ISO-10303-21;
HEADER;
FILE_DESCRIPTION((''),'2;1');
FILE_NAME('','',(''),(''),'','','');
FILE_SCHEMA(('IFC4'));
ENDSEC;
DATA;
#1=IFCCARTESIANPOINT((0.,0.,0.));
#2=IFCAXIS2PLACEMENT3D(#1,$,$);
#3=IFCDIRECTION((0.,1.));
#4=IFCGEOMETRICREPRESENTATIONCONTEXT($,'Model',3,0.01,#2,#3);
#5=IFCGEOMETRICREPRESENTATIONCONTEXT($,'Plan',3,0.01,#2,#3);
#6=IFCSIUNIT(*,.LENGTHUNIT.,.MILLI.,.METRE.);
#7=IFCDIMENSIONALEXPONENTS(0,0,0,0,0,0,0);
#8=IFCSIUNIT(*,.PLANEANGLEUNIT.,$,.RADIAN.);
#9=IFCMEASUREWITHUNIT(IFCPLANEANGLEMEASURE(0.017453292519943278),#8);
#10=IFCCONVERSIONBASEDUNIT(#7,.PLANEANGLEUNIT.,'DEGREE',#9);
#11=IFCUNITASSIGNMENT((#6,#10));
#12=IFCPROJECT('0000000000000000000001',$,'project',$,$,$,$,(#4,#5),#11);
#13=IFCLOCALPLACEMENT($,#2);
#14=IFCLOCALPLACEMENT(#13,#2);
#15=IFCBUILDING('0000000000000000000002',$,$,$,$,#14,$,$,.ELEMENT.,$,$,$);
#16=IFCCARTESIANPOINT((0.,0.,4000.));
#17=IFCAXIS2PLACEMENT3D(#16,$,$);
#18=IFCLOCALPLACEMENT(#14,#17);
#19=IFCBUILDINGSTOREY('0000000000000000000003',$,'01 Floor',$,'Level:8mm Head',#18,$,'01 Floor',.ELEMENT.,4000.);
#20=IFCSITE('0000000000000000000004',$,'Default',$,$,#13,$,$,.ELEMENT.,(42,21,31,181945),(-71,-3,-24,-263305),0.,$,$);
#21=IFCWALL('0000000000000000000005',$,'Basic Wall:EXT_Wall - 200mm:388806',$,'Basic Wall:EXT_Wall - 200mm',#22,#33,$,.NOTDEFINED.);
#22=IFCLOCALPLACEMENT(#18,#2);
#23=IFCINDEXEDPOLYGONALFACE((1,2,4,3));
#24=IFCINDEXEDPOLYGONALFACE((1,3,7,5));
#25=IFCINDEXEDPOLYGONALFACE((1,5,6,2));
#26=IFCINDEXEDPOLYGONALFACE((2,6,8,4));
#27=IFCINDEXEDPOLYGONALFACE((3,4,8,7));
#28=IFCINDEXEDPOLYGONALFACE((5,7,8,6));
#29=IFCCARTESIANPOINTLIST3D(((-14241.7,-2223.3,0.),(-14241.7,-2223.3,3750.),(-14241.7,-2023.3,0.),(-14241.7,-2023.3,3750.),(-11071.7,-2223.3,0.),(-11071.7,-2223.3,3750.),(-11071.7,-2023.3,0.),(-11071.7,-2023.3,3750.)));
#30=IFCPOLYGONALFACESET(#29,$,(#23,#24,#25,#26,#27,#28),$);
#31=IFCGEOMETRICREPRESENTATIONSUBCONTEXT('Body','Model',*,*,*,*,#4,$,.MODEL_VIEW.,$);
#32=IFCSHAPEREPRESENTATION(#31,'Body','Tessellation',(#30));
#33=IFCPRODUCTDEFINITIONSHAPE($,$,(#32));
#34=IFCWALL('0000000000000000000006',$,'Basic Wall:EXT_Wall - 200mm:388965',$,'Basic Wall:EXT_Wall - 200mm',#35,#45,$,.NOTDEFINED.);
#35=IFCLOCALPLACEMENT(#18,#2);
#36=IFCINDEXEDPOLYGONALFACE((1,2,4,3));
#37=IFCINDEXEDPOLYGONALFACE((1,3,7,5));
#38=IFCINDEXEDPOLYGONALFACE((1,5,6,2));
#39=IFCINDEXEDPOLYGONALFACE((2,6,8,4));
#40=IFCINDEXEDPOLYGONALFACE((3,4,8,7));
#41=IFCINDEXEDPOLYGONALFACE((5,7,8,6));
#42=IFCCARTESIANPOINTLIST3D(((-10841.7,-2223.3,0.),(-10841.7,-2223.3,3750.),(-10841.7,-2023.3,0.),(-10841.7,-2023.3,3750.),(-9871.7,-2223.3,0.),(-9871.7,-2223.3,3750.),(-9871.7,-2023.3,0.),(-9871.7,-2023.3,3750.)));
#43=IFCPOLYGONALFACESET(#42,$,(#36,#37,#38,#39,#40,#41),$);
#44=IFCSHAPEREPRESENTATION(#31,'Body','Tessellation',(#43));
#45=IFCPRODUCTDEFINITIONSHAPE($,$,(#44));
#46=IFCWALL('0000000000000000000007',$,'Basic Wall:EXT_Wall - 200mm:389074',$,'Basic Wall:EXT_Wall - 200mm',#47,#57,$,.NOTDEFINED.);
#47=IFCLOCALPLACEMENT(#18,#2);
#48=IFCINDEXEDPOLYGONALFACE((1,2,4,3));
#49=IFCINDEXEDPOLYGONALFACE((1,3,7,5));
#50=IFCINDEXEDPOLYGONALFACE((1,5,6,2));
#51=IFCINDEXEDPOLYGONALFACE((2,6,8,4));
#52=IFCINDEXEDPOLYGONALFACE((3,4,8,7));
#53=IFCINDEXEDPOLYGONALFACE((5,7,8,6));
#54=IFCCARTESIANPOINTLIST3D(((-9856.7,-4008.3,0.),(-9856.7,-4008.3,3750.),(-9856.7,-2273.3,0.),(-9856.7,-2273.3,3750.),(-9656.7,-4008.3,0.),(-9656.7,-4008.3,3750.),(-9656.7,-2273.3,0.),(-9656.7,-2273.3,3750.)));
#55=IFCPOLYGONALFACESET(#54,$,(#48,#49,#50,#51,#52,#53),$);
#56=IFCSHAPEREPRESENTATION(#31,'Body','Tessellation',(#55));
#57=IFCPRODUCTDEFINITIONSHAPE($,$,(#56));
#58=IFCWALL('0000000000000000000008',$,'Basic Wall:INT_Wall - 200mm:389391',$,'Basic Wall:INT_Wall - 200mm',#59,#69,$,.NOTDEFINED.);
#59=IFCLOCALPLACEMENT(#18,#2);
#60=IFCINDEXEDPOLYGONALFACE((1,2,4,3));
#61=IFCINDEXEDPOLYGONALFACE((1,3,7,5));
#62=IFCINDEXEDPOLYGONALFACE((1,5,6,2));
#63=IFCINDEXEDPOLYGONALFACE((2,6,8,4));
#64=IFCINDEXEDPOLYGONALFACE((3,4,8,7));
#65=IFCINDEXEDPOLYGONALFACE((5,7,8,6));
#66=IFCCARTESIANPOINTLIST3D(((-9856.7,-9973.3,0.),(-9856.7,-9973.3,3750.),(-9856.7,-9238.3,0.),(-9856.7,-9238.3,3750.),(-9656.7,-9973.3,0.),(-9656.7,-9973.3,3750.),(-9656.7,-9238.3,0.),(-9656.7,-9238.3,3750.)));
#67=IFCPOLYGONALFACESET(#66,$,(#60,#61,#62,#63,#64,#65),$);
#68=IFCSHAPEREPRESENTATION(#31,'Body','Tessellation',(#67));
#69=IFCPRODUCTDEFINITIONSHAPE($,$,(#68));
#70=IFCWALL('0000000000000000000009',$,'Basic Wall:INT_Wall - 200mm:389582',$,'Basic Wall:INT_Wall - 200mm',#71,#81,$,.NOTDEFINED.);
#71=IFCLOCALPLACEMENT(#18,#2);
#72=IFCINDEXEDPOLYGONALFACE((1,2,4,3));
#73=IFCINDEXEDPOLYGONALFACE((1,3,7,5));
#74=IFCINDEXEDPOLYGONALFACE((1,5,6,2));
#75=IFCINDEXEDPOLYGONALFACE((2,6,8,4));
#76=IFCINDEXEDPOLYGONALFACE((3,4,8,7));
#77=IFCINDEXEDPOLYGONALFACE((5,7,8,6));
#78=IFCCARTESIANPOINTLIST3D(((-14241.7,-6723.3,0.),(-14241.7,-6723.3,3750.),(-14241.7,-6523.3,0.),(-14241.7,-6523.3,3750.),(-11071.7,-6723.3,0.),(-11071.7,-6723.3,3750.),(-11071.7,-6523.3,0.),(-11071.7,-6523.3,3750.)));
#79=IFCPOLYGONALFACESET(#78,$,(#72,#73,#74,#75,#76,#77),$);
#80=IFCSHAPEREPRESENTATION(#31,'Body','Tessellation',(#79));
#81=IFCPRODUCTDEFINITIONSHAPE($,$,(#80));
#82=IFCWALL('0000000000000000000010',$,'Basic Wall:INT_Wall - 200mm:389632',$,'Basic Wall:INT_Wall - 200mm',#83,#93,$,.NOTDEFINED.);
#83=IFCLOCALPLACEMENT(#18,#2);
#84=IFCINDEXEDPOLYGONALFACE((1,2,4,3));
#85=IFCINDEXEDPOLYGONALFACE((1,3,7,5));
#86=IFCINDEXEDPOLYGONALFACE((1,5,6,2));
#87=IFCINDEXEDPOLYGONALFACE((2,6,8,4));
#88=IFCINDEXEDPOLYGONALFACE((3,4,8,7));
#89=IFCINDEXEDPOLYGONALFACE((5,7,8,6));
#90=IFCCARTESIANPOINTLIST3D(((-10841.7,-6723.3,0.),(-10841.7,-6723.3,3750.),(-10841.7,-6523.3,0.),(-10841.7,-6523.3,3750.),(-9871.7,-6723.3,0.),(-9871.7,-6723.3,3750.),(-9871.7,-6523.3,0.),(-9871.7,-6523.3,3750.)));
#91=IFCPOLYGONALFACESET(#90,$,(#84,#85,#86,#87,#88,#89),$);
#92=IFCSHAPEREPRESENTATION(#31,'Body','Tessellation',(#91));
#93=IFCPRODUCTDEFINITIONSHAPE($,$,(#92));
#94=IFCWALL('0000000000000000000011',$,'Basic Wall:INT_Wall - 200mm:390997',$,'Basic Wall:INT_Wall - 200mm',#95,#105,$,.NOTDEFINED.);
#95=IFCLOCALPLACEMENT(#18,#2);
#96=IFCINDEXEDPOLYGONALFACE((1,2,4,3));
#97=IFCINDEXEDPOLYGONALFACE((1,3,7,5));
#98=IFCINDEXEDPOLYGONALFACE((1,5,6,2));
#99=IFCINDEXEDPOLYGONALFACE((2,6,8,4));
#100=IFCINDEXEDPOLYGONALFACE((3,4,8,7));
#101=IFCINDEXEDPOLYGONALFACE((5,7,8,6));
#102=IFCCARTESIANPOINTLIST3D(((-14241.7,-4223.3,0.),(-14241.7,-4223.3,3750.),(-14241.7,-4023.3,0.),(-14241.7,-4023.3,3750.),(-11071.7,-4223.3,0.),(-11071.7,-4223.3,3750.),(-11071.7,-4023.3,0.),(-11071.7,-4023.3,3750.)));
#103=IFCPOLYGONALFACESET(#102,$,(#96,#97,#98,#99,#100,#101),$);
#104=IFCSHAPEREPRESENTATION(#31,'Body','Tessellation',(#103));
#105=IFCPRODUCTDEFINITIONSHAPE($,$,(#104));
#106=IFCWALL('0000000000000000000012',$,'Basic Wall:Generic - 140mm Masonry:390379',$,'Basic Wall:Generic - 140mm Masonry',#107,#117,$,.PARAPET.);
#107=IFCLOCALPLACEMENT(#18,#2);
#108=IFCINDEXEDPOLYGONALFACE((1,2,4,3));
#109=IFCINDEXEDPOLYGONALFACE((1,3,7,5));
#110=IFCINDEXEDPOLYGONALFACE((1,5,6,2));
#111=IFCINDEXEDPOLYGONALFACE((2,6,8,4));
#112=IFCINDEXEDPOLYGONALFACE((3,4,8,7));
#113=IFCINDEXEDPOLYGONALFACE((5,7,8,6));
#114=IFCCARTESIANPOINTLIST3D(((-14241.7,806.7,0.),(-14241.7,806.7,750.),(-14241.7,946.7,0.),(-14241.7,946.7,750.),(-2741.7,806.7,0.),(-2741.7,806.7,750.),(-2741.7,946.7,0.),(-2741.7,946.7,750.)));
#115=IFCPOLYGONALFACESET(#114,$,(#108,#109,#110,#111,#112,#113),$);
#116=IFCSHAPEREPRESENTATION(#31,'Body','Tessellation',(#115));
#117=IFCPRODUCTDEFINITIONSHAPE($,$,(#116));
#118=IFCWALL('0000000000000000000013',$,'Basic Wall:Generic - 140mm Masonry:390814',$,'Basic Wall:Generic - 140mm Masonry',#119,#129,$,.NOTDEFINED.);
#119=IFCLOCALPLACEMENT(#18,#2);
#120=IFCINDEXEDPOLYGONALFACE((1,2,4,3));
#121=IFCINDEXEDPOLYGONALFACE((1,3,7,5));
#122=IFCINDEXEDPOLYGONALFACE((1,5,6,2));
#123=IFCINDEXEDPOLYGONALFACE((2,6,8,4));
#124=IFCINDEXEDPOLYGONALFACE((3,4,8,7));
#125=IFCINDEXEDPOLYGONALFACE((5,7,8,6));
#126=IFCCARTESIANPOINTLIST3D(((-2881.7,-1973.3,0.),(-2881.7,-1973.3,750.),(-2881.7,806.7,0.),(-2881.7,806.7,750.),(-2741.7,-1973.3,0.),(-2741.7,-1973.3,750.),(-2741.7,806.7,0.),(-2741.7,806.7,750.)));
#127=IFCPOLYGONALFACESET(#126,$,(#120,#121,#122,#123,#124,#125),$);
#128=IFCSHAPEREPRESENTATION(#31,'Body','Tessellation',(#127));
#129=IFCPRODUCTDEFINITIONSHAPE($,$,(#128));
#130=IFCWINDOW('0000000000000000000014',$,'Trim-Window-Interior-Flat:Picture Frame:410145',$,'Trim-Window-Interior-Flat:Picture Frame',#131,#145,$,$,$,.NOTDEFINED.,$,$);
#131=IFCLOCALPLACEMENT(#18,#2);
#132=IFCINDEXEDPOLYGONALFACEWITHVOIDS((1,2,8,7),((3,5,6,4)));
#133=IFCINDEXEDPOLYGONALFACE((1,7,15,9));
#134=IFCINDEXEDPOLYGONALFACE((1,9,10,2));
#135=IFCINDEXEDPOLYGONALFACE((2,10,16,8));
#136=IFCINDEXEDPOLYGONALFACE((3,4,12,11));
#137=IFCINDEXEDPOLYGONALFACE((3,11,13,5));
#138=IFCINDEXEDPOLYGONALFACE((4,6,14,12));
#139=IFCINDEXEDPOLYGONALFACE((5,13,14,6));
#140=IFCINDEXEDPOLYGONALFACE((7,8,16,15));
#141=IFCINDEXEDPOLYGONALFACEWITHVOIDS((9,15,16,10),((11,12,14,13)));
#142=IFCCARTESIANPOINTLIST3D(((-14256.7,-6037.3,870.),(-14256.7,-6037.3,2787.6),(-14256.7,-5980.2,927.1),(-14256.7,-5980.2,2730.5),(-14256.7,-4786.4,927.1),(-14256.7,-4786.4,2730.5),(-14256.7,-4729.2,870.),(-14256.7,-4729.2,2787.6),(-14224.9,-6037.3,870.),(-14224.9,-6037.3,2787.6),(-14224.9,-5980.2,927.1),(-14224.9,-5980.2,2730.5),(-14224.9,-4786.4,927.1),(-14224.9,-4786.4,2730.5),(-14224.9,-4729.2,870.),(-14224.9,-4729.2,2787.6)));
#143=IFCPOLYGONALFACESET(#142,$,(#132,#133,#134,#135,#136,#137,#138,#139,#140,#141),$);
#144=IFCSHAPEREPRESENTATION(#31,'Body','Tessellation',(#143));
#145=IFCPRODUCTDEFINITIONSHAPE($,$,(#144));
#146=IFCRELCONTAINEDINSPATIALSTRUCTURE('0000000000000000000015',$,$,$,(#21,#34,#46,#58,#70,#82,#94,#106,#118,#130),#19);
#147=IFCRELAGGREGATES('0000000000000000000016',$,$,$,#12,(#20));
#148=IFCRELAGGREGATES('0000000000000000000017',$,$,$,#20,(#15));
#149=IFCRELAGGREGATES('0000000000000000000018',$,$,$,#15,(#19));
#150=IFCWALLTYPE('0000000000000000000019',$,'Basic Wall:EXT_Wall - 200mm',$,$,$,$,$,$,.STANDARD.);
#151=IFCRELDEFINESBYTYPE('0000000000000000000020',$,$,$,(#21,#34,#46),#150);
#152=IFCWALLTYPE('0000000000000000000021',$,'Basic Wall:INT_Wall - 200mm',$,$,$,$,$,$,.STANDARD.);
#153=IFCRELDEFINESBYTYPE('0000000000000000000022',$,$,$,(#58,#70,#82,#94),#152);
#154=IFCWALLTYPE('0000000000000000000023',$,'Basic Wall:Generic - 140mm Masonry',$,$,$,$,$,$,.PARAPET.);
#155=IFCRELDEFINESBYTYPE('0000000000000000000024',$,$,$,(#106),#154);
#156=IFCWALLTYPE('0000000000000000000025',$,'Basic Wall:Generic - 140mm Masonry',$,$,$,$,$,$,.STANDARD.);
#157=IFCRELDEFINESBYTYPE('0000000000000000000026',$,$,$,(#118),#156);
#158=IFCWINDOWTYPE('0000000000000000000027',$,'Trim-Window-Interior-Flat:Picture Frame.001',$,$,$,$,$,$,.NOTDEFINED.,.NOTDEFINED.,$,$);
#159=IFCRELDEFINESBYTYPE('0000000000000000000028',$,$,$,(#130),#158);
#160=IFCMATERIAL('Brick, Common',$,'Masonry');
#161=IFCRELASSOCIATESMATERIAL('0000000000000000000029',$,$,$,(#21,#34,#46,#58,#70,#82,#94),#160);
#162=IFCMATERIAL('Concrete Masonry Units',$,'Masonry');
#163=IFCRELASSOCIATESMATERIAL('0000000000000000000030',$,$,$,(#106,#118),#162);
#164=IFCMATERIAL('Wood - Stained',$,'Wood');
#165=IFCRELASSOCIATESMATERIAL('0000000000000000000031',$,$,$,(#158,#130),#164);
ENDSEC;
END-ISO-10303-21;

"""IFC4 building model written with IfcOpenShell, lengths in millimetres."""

from ifc_helpers import new_model, entity, si_unit, converted_unit, direction, frame, origin, place, context, subcontext, project, spatial, indexed_curve, outline, extrude, source, transform, mapped, material, type_object, type_shapes, element, save


model = new_model("IFC4")

# Units and contexts
model_context = context("Model", 3, precision=0.01, world=origin(), true_north=direction((0.0, 1.0)))
plan_context = context("Plan", 3, precision=0.01, world=origin(), true_north=direction((0.0, 1.0)))
body_context = subcontext(model_context, "Body", "Model", "MODEL_VIEW")
ifc_project = project(units=[si_unit("LENGTHUNIT", "METRE", prefix="MILLI"), converted_unit("PLANEANGLEUNIT", "DEGREE", entity("IfcPlaneAngleMeasure", 0.017453292519943278), si_unit("PLANEANGLEUNIT", "RADIAN"), dimensions=[0, 0, 0, 0, 0, 0, 0])], contexts=[model_context, plan_context])

# Site, building, storey
site_placement = place(None, origin())
site = spatial("IfcSite", under=ifc_project, at=site_placement, Name="Default", CompositionType="ELEMENT", RefLatitude=(42, 21, 31, 181945), RefLongitude=(-71, -3, -24, -263305), RefElevation=0.0)
building_placement = place(site_placement, origin())
building = spatial("IfcBuilding", under=site, at=building_placement, CompositionType="ELEMENT")
storey_placement = place(building_placement, frame((0.0, 0.0, 4000.0)))
storey = spatial("IfcBuildingStorey", under=building, at=storey_placement, Name="01 Floor", ObjectType="Level:8mm Head", LongName="01 Floor", CompositionType="ELEMENT", Elevation=4000.0)

# Walls
ifc_material_1 = material(Name="Brick, Common", Category="Masonry")
wall_type_1 = type_object("IfcWallType", Name="Basic Wall:EXT_Wall - 200mm", PredefinedType="STANDARD")
wall_1_placement = place(storey_placement, frame((-14241.7, -2123.3, 0.0)))
element("IfcWall", 1, at=wall_1_placement, inside=storey, type_object=wall_type_1, material=ifc_material_1, Name="Basic Wall:EXT_Wall - 200mm:388806", ObjectType="Basic Wall:EXT_Wall - 200mm", PredefinedType="NOTDEFINED", context=body_context, shape_type="SweptSolid", body=[
    extrude(outline(indexed_curve([(3170.0, 100.0), (0.0, 100.0), (0.0, -100.0), (3170.0, -100.0), (3170.0, 100.0)], self_intersect=False)), origin(), (0.0, 0.0, 1.0), 3750.0),
])
wall_2_placement = place(storey_placement, frame((-10841.7, -2123.3, 0.0)))
element("IfcWall", 2, at=wall_2_placement, inside=storey, type_object=wall_type_1, material=ifc_material_1, Name="Basic Wall:EXT_Wall - 200mm:388965", ObjectType="Basic Wall:EXT_Wall - 200mm", PredefinedType="NOTDEFINED", context=body_context, shape_type="SweptSolid", body=[
    extrude(outline(indexed_curve([(970.0, 100.0), (0.0, 100.0), (0.0, -100.0), (970.0, -100.0), (970.0, 100.0)], self_intersect=False)), origin(), (0.0, 0.0, 1.0), 3750.0),
])
wall_3_placement = place(storey_placement, frame((-9756.7, -2273.3, 0.0), z_axis=(0.0, 0.0, 1.0), x_axis=(0.0, -1.0, 0.0)))
element("IfcWall", 3, at=wall_3_placement, inside=storey, type_object=wall_type_1, material=ifc_material_1, Name="Basic Wall:EXT_Wall - 200mm:389074", ObjectType="Basic Wall:EXT_Wall - 200mm", PredefinedType="NOTDEFINED", context=body_context, shape_type="SweptSolid", body=[
    extrude(outline(indexed_curve([(1735.0, 100.0), (0.0, 100.0), (0.0, -100.0), (1735.0, -100.0), (1735.0, 100.0)], self_intersect=False)), origin(), (0.0, 0.0, 1.0), 3750.0),
])
wall_type_2 = type_object("IfcWallType", Name="Basic Wall:INT_Wall - 200mm", PredefinedType="STANDARD")
wall_4_placement = place(storey_placement, frame((-9756.7, -9973.3, 0.0), z_axis=(0.0, 0.0, 1.0), x_axis=(0.0, 1.0, 0.0)))
element("IfcWall", 4, at=wall_4_placement, inside=storey, type_object=wall_type_2, material=ifc_material_1, Name="Basic Wall:INT_Wall - 200mm:389391", ObjectType="Basic Wall:INT_Wall - 200mm", PredefinedType="NOTDEFINED", context=body_context, shape_type="SweptSolid", body=[
    extrude(outline(indexed_curve([(735.0, 100.0), (0.0, 100.0), (0.0, -100.0), (735.0, -100.0), (735.0, 100.0)], self_intersect=False)), origin(), (0.0, 0.0, 1.0), 3750.0),
])
wall_5_placement = place(storey_placement, frame((-14241.7, -6623.3, 0.0)))
element("IfcWall", 5, at=wall_5_placement, inside=storey, type_object=wall_type_2, material=ifc_material_1, Name="Basic Wall:INT_Wall - 200mm:389582", ObjectType="Basic Wall:INT_Wall - 200mm", PredefinedType="NOTDEFINED", context=body_context, shape_type="SweptSolid", body=[
    extrude(outline(indexed_curve([(3170.0, 100.0), (0.0, 100.0), (0.0, -100.0), (3170.0, -100.0), (3170.0, 100.0)], self_intersect=False)), origin(), (0.0, 0.0, 1.0), 3750.0),
])
wall_6_placement = place(storey_placement, frame((-10841.7, -6623.3, 0.0)))
element("IfcWall", 6, at=wall_6_placement, inside=storey, type_object=wall_type_2, material=ifc_material_1, Name="Basic Wall:INT_Wall - 200mm:389632", ObjectType="Basic Wall:INT_Wall - 200mm", PredefinedType="NOTDEFINED", context=body_context, shape_type="SweptSolid", body=[
    extrude(outline(indexed_curve([(970.0, 100.0), (0.0, 100.0), (0.0, -100.0), (970.0, -100.0), (970.0, 100.0)], self_intersect=False)), origin(), (0.0, 0.0, 1.0), 3750.0),
])
wall_7_placement = place(storey_placement, frame((-14241.7, -4123.3, 0.0)))
element("IfcWall", 7, at=wall_7_placement, inside=storey, type_object=wall_type_2, material=ifc_material_1, Name="Basic Wall:INT_Wall - 200mm:390997", ObjectType="Basic Wall:INT_Wall - 200mm", PredefinedType="NOTDEFINED", context=body_context, shape_type="SweptSolid", body=[
    extrude(outline(indexed_curve([(3170.0, 100.0), (0.0, 100.0), (0.0, -100.0), (3170.0, -100.0), (3170.0, 100.0)], self_intersect=False)), origin(), (0.0, 0.0, 1.0), 3750.0),
])
ifc_material_2 = material(Name="Concrete Masonry Units", Category="Masonry")
wall_type_3 = type_object("IfcWallType", Name="Basic Wall:Generic - 140mm Masonry", PredefinedType="PARAPET")
wall_8_placement = place(storey_placement, frame((-14241.7, 876.7, 0.0)))
element("IfcWall", 8, at=wall_8_placement, inside=storey, type_object=wall_type_3, material=ifc_material_2, Name="Basic Wall:Generic - 140mm Masonry:390379", ObjectType="Basic Wall:Generic - 140mm Masonry", PredefinedType="PARAPET", context=body_context, shape_type="SweptSolid", body=[
    extrude(outline(indexed_curve([(11500.0, 70.0), (0.0, 70.0), (0.0, -70.0), (11500.0, -70.0), (11500.0, 70.0)], self_intersect=False)), origin(), (0.0, 0.0, 1.0), 750.0),
])
wall_type_4 = type_object("IfcWallType", Name="Basic Wall:Generic - 140mm Masonry", PredefinedType="STANDARD")
wall_9_placement = place(storey_placement, frame((-2811.7, -1973.3, 0.0), z_axis=(0.0, 0.0, 1.0), x_axis=(0.0, 1.0, 0.0)))
element("IfcWall", 9, at=wall_9_placement, inside=storey, type_object=wall_type_4, material=ifc_material_2, Name="Basic Wall:Generic - 140mm Masonry:390814", ObjectType="Basic Wall:Generic - 140mm Masonry", PredefinedType="NOTDEFINED", context=body_context, shape_type="SweptSolid", body=[
    extrude(outline(indexed_curve([(2780.0, 70.0), (0.0, 70.0), (0.0, -70.0), (2780.0, -70.0), (2780.0, 70.0)], self_intersect=False)), origin(), (0.0, 0.0, 1.0), 750.0),
])

# Window
ifc_material_3 = material(Name="Wood - Stained", Category="Wood")
window_type = type_object("IfcWindowType", Name="Trim-Window-Interior-Flat:Picture Frame.001", PredefinedType="NOTDEFINED", material=ifc_material_3)
shared_shape_1 = source(origin(), body_context, "Body", "SweptSolid", [
    extrude(outline(indexed_curve([(-654.0, -958.8), (654.0, -958.8), (654.0, 958.8), (-654.0, 958.8), (-654.0, -958.8)], self_intersect=False), holes=[indexed_curve([(-596.9, -901.7), (-596.9, 901.7), (596.9, 901.7), (596.9, -901.7), (-596.9, -901.7)], self_intersect=False)]), frame((0.0, -914.4, 0.0), z_axis=(0.0, 0.0, 1.0), x_axis=(-1.0, 0.0, 0.0)), (0.0, 0.0, 1.0), 31.7),
])
type_shapes(window_type, [shared_shape_1])
window_placement = place(storey_placement, frame((-14256.7, -5383.3, 2743.2), z_axis=(1.0, 0.0, 0.0), x_axis=(0.0, 1.0, 0.0)))
element("IfcWindow", 10, at=window_placement, inside=storey, type_object=window_type, material=ifc_material_3, Name="Trim-Window-Interior-Flat:Picture Frame:410145", ObjectType="Trim-Window-Interior-Flat:Picture Frame", PredefinedType="NOTDEFINED", context=body_context, shape_type="MappedRepresentation", body=[
    mapped(shared_shape_1, transform((0.0, 0.0, 0.0), scale=1.0)),
])

save(model, "model.ifc")
